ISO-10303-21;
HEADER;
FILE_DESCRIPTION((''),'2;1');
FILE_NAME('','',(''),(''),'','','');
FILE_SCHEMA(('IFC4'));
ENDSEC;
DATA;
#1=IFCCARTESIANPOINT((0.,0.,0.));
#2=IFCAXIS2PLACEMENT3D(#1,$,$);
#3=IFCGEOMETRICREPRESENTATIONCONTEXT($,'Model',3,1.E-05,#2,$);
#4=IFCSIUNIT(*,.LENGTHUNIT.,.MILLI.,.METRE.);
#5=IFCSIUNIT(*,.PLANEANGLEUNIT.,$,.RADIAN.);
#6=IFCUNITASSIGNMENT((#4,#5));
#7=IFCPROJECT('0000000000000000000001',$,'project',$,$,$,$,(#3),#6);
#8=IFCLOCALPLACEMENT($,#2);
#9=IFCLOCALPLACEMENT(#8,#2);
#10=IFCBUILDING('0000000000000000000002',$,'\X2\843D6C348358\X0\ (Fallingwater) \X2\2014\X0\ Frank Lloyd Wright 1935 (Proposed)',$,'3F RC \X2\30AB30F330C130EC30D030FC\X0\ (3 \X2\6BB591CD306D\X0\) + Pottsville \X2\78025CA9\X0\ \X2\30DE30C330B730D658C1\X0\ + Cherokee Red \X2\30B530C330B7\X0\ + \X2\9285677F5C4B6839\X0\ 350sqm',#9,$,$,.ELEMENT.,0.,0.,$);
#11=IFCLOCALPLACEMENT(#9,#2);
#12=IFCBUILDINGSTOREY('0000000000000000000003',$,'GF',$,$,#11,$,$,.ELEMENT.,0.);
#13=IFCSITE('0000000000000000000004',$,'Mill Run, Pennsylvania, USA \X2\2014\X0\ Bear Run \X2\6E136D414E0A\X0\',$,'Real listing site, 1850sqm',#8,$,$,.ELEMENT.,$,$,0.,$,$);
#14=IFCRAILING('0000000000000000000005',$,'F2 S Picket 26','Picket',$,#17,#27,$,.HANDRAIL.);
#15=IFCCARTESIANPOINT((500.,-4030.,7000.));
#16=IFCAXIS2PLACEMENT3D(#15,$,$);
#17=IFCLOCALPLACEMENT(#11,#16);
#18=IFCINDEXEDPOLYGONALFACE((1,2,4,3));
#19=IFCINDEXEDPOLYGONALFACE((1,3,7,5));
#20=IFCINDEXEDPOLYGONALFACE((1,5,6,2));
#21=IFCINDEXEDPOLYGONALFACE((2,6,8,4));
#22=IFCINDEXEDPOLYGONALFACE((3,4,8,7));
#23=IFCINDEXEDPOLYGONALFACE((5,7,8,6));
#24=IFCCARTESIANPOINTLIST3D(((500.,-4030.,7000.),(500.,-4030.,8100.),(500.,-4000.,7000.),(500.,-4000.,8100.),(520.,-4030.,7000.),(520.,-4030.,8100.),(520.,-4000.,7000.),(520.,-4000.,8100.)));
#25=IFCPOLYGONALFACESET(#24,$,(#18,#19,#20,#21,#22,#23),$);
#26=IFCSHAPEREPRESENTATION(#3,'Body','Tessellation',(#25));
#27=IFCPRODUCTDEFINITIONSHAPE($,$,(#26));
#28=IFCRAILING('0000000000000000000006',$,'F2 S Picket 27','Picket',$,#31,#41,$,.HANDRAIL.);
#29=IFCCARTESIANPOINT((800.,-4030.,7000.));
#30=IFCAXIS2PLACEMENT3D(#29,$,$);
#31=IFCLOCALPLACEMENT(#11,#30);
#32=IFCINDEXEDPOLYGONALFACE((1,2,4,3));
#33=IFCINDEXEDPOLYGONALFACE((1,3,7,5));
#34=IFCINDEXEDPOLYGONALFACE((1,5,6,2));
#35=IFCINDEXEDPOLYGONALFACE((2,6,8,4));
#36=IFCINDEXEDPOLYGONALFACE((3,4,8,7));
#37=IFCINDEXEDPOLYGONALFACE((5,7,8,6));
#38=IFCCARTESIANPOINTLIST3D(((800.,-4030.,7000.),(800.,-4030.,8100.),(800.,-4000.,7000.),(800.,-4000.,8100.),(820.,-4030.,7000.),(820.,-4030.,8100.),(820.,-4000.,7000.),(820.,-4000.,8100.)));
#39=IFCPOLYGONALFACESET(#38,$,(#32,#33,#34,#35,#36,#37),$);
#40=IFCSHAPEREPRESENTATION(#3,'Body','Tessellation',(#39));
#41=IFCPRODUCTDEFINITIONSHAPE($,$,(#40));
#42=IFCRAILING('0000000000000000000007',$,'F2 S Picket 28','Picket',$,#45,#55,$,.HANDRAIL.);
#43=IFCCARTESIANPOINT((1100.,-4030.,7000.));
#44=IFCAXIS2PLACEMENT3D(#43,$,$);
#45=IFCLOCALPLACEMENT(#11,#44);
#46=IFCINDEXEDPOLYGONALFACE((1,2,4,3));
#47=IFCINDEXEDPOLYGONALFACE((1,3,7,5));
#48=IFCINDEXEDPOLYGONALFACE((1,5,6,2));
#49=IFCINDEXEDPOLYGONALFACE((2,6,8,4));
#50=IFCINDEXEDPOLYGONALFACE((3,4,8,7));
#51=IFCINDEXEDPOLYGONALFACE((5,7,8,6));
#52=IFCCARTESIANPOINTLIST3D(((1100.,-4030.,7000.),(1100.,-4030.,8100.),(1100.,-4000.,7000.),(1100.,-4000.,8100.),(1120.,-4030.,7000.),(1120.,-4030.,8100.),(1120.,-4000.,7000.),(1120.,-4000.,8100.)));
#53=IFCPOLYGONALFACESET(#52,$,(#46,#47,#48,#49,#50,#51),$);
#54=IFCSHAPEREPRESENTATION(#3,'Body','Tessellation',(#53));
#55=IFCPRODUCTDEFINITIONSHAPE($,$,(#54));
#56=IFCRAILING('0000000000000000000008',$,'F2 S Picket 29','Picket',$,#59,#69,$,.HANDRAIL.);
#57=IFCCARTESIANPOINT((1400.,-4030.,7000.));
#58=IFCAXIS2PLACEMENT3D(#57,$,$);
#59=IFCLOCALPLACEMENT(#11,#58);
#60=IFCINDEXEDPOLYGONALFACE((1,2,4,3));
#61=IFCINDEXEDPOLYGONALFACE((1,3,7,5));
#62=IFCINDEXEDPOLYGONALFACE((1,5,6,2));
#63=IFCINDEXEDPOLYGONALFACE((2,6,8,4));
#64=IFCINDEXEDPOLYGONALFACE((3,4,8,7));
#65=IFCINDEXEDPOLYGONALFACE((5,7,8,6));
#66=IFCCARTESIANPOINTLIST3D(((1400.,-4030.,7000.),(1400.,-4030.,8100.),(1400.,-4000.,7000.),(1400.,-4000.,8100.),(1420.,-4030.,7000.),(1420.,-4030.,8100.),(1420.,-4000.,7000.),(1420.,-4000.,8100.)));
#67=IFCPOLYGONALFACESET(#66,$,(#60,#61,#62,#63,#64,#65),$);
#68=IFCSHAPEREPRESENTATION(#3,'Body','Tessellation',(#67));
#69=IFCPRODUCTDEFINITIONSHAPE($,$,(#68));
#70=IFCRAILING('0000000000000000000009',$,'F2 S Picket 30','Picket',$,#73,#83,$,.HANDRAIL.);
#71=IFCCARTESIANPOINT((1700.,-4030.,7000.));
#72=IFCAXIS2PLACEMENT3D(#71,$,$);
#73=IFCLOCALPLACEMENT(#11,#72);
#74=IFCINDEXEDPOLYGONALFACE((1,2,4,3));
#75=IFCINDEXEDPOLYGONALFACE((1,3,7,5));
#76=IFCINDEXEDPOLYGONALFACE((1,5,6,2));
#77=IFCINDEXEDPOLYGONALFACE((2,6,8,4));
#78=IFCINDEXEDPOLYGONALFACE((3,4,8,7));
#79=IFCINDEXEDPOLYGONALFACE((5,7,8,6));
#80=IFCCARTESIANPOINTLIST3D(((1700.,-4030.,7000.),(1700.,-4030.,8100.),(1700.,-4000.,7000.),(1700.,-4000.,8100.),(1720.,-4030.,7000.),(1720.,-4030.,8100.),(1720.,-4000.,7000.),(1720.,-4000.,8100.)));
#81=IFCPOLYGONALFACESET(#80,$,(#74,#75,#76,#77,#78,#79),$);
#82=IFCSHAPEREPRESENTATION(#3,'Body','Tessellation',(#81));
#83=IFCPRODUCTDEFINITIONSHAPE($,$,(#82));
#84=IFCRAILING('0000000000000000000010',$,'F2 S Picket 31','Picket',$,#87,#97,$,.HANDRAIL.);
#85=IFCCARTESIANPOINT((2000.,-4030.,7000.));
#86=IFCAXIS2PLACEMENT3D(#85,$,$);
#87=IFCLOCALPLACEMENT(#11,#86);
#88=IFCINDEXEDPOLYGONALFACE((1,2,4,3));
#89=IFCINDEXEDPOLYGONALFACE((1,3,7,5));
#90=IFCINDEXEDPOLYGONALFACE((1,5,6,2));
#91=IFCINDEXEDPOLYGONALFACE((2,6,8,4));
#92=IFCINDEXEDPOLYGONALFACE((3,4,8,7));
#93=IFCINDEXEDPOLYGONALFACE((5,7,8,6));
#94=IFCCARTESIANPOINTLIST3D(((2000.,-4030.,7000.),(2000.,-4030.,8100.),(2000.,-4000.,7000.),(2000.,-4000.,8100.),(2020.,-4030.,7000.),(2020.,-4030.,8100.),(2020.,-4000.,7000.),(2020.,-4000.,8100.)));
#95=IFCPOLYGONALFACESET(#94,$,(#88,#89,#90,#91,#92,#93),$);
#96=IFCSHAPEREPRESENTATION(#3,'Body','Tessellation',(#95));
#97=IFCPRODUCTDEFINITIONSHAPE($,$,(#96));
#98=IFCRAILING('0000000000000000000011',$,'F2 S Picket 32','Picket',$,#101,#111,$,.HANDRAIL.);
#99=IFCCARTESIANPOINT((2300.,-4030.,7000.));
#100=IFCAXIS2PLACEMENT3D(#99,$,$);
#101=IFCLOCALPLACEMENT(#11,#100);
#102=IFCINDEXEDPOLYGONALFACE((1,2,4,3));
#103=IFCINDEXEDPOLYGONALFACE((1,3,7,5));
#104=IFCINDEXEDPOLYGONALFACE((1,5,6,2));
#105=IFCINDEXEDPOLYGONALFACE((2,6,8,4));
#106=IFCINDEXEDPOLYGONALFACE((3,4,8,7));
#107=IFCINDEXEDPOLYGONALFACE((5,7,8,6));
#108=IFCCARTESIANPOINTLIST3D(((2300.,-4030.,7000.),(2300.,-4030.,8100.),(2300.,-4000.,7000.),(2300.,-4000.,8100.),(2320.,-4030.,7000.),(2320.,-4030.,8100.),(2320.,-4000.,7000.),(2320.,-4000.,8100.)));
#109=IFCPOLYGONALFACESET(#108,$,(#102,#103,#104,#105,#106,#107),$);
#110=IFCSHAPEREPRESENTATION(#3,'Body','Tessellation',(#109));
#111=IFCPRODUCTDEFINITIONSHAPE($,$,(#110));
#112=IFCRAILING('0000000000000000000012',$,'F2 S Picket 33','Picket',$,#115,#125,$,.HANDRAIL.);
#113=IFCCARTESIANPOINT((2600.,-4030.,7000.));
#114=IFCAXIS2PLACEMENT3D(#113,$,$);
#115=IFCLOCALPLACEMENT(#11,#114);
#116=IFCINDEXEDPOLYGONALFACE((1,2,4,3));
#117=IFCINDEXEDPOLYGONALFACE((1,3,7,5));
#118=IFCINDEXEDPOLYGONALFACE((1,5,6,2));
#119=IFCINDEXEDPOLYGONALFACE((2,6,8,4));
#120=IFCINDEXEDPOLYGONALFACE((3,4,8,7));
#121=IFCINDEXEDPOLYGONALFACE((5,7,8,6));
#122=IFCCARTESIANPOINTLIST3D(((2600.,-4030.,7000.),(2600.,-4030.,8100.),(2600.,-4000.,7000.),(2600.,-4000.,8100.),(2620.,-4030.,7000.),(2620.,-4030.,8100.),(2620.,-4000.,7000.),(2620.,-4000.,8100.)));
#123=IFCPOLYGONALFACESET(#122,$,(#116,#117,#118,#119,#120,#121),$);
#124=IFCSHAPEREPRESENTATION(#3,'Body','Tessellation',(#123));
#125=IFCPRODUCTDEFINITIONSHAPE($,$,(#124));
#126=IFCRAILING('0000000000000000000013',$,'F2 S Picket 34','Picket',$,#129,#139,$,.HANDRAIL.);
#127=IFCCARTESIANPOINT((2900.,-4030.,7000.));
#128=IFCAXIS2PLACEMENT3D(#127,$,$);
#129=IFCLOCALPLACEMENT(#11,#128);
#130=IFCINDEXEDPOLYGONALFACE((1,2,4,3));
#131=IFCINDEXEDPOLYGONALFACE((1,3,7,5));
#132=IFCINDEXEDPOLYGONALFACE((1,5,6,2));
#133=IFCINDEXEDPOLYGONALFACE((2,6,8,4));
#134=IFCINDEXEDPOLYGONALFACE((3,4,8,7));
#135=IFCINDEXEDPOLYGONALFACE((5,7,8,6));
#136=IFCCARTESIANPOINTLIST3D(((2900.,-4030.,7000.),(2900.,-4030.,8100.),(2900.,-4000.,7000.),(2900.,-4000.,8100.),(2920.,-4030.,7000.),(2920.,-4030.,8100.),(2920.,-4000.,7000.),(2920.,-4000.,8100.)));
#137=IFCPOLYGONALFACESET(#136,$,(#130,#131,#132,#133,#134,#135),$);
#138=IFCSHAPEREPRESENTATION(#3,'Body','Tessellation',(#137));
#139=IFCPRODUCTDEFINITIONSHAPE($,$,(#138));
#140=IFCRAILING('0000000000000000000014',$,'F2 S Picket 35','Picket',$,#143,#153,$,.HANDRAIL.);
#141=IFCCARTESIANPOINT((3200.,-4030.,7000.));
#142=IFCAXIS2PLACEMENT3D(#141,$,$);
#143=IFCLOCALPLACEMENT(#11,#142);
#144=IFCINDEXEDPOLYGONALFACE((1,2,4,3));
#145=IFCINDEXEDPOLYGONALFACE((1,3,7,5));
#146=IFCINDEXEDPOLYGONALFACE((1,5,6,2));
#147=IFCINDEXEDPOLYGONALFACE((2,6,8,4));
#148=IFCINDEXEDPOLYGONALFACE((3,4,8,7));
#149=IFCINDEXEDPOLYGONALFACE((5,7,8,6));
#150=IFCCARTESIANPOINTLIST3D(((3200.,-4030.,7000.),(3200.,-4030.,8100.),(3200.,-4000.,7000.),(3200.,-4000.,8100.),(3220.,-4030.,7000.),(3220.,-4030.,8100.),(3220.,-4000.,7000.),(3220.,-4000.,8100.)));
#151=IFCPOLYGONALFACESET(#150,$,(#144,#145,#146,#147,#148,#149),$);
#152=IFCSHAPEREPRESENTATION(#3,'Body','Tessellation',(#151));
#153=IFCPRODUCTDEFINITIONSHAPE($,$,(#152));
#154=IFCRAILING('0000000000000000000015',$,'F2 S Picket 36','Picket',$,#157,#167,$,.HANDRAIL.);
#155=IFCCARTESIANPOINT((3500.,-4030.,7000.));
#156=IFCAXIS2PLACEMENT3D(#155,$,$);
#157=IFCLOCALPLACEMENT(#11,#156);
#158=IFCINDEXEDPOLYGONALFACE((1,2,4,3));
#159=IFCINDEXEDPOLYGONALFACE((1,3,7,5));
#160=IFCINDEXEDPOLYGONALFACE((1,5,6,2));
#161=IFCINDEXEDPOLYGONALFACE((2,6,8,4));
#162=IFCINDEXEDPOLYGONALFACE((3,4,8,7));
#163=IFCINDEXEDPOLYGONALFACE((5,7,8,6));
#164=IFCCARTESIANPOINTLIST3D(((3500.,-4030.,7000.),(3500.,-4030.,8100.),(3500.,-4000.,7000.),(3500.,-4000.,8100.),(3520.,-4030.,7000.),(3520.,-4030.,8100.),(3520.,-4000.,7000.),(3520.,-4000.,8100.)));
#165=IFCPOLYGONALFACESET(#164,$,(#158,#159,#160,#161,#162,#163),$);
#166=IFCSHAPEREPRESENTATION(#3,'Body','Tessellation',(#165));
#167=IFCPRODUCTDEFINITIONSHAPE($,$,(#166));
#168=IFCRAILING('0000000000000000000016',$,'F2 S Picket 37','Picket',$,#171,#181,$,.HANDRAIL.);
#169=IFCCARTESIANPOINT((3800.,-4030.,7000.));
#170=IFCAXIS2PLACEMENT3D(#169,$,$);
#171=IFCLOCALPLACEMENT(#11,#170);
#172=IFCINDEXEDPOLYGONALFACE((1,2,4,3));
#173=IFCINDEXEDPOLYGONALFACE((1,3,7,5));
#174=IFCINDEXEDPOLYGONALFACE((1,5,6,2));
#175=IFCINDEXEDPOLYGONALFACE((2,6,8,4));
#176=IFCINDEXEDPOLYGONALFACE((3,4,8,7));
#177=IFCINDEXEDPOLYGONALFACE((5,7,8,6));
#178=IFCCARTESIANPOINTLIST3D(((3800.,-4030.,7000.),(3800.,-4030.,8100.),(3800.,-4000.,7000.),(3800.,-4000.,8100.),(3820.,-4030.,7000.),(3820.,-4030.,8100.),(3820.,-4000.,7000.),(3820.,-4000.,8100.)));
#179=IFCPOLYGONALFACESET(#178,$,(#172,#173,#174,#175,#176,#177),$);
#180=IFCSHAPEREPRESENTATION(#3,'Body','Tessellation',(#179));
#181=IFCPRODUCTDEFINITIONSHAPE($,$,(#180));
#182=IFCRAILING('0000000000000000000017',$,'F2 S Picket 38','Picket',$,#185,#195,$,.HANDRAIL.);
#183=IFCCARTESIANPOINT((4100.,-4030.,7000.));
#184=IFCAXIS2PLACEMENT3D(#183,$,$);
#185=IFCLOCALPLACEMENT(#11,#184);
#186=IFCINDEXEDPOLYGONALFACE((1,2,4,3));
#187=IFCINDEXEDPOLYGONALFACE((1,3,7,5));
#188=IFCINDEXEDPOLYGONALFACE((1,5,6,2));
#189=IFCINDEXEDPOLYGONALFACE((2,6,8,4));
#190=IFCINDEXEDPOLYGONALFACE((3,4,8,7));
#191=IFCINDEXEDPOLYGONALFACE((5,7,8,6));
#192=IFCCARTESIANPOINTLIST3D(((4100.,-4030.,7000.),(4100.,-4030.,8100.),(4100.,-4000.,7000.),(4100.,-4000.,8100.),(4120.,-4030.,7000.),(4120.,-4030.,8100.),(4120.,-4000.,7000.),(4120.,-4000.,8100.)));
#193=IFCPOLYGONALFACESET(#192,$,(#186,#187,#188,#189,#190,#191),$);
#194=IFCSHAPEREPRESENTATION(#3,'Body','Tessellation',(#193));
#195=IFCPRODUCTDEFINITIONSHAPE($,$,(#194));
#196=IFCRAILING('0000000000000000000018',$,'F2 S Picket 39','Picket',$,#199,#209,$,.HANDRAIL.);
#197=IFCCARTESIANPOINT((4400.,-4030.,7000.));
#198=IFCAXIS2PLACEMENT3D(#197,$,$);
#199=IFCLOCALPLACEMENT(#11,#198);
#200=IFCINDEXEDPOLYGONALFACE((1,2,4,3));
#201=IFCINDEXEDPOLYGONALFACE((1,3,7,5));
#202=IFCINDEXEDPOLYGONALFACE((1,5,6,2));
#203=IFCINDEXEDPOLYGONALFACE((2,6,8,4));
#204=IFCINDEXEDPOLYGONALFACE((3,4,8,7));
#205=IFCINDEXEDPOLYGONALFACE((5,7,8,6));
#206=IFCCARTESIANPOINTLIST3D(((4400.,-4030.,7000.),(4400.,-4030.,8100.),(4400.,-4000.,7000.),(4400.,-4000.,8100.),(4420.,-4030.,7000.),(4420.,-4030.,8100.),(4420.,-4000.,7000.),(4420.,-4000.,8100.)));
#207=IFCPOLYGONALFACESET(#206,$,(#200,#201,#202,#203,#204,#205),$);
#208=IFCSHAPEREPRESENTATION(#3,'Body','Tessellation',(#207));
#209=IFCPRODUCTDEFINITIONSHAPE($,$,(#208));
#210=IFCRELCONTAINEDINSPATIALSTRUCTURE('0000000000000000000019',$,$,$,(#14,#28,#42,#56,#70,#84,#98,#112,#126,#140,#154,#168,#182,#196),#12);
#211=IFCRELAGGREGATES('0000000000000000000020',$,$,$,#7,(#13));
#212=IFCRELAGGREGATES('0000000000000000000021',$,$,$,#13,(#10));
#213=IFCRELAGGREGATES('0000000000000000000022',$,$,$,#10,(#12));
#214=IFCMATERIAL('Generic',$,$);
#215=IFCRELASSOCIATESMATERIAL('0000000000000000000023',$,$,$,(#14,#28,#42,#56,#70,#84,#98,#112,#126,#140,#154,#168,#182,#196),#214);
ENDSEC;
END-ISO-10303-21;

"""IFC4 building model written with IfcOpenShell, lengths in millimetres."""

from ifc_helpers import new_model, si_unit, frame, frame_2d, origin, place, context, project, spatial, rectangle, extrude, material, element, save


model = new_model("IFC4")

# Units and contexts
model_context = context("Model", 3, precision=1e-05, world=origin())
ifc_project = project(units=[si_unit("LENGTHUNIT", "METRE", prefix="MILLI"), si_unit("PLANEANGLEUNIT", "RADIAN")], contexts=[model_context])

# Site, building, storey
site_placement = place(None, origin())
site = spatial("IfcSite", under=ifc_project, at=site_placement, Name="Mill Run, Pennsylvania, USA — Bear Run 渓流上", ObjectType="Real listing site, 1850sqm", CompositionType="ELEMENT", RefElevation=0.0)
building_placement = place(site_placement, origin())
building = spatial("IfcBuilding", under=site, at=building_placement, Name="落水荘 (Fallingwater) — Frank Lloyd Wright 1935 (Proposed)", ObjectType="3F RC カンチレバー (3 段重ね) + Pottsville 砂岩 マッシブ壁 + Cherokee Red サッシ + 銅板屋根 350sqm", CompositionType="ELEMENT", ElevationOfRefHeight=0.0, ElevationOfTerrain=0.0)
storey_placement = place(building_placement, origin())
storey = spatial("IfcBuildingStorey", under=building, at=storey_placement, Name="GF", CompositionType="ELEMENT", Elevation=0.0)

# Railings
ifc_material_1 = material(Name="Generic")
railing_1_placement = place(storey_placement, frame((500.0, -4030.0, 7000.0)))
element("IfcRailing", 1, at=railing_1_placement, inside=storey, material=ifc_material_1, Name="F2 S Picket 26", Description="Picket", PredefinedType="HANDRAIL", context=model_context, shape_type="SweptSolid", body=[
    extrude(rectangle(XDim=20.0, YDim=30.0, at=frame_2d((10.0, 15.0))), frame((500.0, -4030.0, 7000.0)), (0.0, 0.0, 1.0), 1100.0),
])
railing_2_placement = place(storey_placement, frame((800.0, -4030.0, 7000.0)))
element("IfcRailing", 2, at=railing_2_placement, inside=storey, material=ifc_material_1, Name="F2 S Picket 27", Description="Picket", PredefinedType="HANDRAIL", context=model_context, shape_type="SweptSolid", body=[
    extrude(rectangle(XDim=20.0, YDim=30.0, at=frame_2d((10.0, 15.0))), frame((800.0, -4030.0, 7000.0)), (0.0, 0.0, 1.0), 1100.0),
])
railing_3_placement = place(storey_placement, frame((1100.0, -4030.0, 7000.0)))
element("IfcRailing", 3, at=railing_3_placement, inside=storey, material=ifc_material_1, Name="F2 S Picket 28", Description="Picket", PredefinedType="HANDRAIL", context=model_context, shape_type="SweptSolid", body=[
    extrude(rectangle(XDim=20.0, YDim=30.0, at=frame_2d((10.0, 15.0))), frame((1100.0, -4030.0, 7000.0)), (0.0, 0.0, 1.0), 1100.0),
])
railing_4_placement = place(storey_placement, frame((1400.0, -4030.0, 7000.0)))
element("IfcRailing", 4, at=railing_4_placement, inside=storey, material=ifc_material_1, Name="F2 S Picket 29", Description="Picket", PredefinedType="HANDRAIL", context=model_context, shape_type="SweptSolid", body=[
    extrude(rectangle(XDim=20.0, YDim=30.0, at=frame_2d((10.0, 15.0))), frame((1400.0, -4030.0, 7000.0)), (0.0, 0.0, 1.0), 1100.0),
])
railing_5_placement = place(storey_placement, frame((1700.0, -4030.0, 7000.0)))
element("IfcRailing", 5, at=railing_5_placement, inside=storey, material=ifc_material_1, Name="F2 S Picket 30", Description="Picket", PredefinedType="HANDRAIL", context=model_context, shape_type="SweptSolid", body=[
    extrude(rectangle(XDim=20.0, YDim=30.0, at=frame_2d((10.0, 15.0))), frame((1700.0, -4030.0, 7000.0)), (0.0, 0.0, 1.0), 1100.0),
])
railing_6_placement = place(storey_placement, frame((2000.0, -4030.0, 7000.0)))
element("IfcRailing", 6, at=railing_6_placement, inside=storey, material=ifc_material_1, Name="F2 S Picket 31", Description="Picket", PredefinedType="HANDRAIL", context=model_context, shape_type="SweptSolid", body=[
    extrude(rectangle(XDim=20.0, YDim=30.0, at=frame_2d((10.0, 15.0))), frame((2000.0, -4030.0, 7000.0)), (0.0, 0.0, 1.0), 1100.0),
])
railing_7_placement = place(storey_placement, frame((2300.0, -4030.0, 7000.0)))
element("IfcRailing", 7, at=railing_7_placement, inside=storey, material=ifc_material_1, Name="F2 S Picket 32", Description="Picket", PredefinedType="HANDRAIL", context=model_context, shape_type="SweptSolid", body=[
    extrude(rectangle(XDim=20.0, YDim=30.0, at=frame_2d((10.0, 15.0))), frame((2300.0, -4030.0, 7000.0)), (0.0, 0.0, 1.0), 1100.0),
])
railing_8_placement = place(storey_placement, frame((2600.0, -4030.0, 7000.0)))
element("IfcRailing", 8, at=railing_8_placement, inside=storey, material=ifc_material_1, Name="F2 S Picket 33", Description="Picket", PredefinedType="HANDRAIL", context=model_context, shape_type="SweptSolid", body=[
    extrude(rectangle(XDim=20.0, YDim=30.0, at=frame_2d((10.0, 15.0))), frame((2600.0, -4030.0, 7000.0)), (0.0, 0.0, 1.0), 1100.0),
])
railing_9_placement = place(storey_placement, frame((2900.0, -4030.0, 7000.0)))
element("IfcRailing", 9, at=railing_9_placement, inside=storey, material=ifc_material_1, Name="F2 S Picket 34", Description="Picket", PredefinedType="HANDRAIL", context=model_context, shape_type="SweptSolid", body=[
    extrude(rectangle(XDim=20.0, YDim=30.0, at=frame_2d((10.0, 15.0))), frame((2900.0, -4030.0, 7000.0)), (0.0, 0.0, 1.0), 1100.0),
])
railing_10_placement = place(storey_placement, frame((3200.0, -4030.0, 7000.0)))
element("IfcRailing", 10, at=railing_10_placement, inside=storey, material=ifc_material_1, Name="F2 S Picket 35", Description="Picket", PredefinedType="HANDRAIL", context=model_context, shape_type="SweptSolid", body=[
    extrude(rectangle(XDim=20.0, YDim=30.0, at=frame_2d((10.0, 15.0))), frame((3200.0, -4030.0, 7000.0)), (0.0, 0.0, 1.0), 1100.0),
])
railing_11_placement = place(storey_placement, frame((3500.0, -4030.0, 7000.0)))
element("IfcRailing", 11, at=railing_11_placement, inside=storey, material=ifc_material_1, Name="F2 S Picket 36", Description="Picket", PredefinedType="HANDRAIL", context=model_context, shape_type="SweptSolid", body=[
    extrude(rectangle(XDim=20.0, YDim=30.0, at=frame_2d((10.0, 15.0))), frame((3500.0, -4030.0, 7000.0)), (0.0, 0.0, 1.0), 1100.0),
])
railing_12_placement = place(storey_placement, frame((3800.0, -4030.0, 7000.0)))
element("IfcRailing", 12, at=railing_12_placement, inside=storey, material=ifc_material_1, Name="F2 S Picket 37", Description="Picket", PredefinedType="HANDRAIL", context=model_context, shape_type="SweptSolid", body=[
    extrude(rectangle(XDim=20.0, YDim=30.0, at=frame_2d((10.0, 15.0))), frame((3800.0, -4030.0, 7000.0)), (0.0, 0.0, 1.0), 1100.0),
])
railing_13_placement = place(storey_placement, frame((4100.0, -4030.0, 7000.0)))
element("IfcRailing", 13, at=railing_13_placement, inside=storey, material=ifc_material_1, Name="F2 S Picket 38", Description="Picket", PredefinedType="HANDRAIL", context=model_context, shape_type="SweptSolid", body=[
    extrude(rectangle(XDim=20.0, YDim=30.0, at=frame_2d((10.0, 15.0))), frame((4100.0, -4030.0, 7000.0)), (0.0, 0.0, 1.0), 1100.0),
])
railing_14_placement = place(storey_placement, frame((4400.0, -4030.0, 7000.0)))
element("IfcRailing", 14, at=railing_14_placement, inside=storey, material=ifc_material_1, Name="F2 S Picket 39", Description="Picket", PredefinedType="HANDRAIL", context=model_context, shape_type="SweptSolid", body=[
    extrude(rectangle(XDim=20.0, YDim=30.0, at=frame_2d((10.0, 15.0))), frame((4400.0, -4030.0, 7000.0)), (0.0, 0.0, 1.0), 1100.0),
])

save(model, "model.ifc")
